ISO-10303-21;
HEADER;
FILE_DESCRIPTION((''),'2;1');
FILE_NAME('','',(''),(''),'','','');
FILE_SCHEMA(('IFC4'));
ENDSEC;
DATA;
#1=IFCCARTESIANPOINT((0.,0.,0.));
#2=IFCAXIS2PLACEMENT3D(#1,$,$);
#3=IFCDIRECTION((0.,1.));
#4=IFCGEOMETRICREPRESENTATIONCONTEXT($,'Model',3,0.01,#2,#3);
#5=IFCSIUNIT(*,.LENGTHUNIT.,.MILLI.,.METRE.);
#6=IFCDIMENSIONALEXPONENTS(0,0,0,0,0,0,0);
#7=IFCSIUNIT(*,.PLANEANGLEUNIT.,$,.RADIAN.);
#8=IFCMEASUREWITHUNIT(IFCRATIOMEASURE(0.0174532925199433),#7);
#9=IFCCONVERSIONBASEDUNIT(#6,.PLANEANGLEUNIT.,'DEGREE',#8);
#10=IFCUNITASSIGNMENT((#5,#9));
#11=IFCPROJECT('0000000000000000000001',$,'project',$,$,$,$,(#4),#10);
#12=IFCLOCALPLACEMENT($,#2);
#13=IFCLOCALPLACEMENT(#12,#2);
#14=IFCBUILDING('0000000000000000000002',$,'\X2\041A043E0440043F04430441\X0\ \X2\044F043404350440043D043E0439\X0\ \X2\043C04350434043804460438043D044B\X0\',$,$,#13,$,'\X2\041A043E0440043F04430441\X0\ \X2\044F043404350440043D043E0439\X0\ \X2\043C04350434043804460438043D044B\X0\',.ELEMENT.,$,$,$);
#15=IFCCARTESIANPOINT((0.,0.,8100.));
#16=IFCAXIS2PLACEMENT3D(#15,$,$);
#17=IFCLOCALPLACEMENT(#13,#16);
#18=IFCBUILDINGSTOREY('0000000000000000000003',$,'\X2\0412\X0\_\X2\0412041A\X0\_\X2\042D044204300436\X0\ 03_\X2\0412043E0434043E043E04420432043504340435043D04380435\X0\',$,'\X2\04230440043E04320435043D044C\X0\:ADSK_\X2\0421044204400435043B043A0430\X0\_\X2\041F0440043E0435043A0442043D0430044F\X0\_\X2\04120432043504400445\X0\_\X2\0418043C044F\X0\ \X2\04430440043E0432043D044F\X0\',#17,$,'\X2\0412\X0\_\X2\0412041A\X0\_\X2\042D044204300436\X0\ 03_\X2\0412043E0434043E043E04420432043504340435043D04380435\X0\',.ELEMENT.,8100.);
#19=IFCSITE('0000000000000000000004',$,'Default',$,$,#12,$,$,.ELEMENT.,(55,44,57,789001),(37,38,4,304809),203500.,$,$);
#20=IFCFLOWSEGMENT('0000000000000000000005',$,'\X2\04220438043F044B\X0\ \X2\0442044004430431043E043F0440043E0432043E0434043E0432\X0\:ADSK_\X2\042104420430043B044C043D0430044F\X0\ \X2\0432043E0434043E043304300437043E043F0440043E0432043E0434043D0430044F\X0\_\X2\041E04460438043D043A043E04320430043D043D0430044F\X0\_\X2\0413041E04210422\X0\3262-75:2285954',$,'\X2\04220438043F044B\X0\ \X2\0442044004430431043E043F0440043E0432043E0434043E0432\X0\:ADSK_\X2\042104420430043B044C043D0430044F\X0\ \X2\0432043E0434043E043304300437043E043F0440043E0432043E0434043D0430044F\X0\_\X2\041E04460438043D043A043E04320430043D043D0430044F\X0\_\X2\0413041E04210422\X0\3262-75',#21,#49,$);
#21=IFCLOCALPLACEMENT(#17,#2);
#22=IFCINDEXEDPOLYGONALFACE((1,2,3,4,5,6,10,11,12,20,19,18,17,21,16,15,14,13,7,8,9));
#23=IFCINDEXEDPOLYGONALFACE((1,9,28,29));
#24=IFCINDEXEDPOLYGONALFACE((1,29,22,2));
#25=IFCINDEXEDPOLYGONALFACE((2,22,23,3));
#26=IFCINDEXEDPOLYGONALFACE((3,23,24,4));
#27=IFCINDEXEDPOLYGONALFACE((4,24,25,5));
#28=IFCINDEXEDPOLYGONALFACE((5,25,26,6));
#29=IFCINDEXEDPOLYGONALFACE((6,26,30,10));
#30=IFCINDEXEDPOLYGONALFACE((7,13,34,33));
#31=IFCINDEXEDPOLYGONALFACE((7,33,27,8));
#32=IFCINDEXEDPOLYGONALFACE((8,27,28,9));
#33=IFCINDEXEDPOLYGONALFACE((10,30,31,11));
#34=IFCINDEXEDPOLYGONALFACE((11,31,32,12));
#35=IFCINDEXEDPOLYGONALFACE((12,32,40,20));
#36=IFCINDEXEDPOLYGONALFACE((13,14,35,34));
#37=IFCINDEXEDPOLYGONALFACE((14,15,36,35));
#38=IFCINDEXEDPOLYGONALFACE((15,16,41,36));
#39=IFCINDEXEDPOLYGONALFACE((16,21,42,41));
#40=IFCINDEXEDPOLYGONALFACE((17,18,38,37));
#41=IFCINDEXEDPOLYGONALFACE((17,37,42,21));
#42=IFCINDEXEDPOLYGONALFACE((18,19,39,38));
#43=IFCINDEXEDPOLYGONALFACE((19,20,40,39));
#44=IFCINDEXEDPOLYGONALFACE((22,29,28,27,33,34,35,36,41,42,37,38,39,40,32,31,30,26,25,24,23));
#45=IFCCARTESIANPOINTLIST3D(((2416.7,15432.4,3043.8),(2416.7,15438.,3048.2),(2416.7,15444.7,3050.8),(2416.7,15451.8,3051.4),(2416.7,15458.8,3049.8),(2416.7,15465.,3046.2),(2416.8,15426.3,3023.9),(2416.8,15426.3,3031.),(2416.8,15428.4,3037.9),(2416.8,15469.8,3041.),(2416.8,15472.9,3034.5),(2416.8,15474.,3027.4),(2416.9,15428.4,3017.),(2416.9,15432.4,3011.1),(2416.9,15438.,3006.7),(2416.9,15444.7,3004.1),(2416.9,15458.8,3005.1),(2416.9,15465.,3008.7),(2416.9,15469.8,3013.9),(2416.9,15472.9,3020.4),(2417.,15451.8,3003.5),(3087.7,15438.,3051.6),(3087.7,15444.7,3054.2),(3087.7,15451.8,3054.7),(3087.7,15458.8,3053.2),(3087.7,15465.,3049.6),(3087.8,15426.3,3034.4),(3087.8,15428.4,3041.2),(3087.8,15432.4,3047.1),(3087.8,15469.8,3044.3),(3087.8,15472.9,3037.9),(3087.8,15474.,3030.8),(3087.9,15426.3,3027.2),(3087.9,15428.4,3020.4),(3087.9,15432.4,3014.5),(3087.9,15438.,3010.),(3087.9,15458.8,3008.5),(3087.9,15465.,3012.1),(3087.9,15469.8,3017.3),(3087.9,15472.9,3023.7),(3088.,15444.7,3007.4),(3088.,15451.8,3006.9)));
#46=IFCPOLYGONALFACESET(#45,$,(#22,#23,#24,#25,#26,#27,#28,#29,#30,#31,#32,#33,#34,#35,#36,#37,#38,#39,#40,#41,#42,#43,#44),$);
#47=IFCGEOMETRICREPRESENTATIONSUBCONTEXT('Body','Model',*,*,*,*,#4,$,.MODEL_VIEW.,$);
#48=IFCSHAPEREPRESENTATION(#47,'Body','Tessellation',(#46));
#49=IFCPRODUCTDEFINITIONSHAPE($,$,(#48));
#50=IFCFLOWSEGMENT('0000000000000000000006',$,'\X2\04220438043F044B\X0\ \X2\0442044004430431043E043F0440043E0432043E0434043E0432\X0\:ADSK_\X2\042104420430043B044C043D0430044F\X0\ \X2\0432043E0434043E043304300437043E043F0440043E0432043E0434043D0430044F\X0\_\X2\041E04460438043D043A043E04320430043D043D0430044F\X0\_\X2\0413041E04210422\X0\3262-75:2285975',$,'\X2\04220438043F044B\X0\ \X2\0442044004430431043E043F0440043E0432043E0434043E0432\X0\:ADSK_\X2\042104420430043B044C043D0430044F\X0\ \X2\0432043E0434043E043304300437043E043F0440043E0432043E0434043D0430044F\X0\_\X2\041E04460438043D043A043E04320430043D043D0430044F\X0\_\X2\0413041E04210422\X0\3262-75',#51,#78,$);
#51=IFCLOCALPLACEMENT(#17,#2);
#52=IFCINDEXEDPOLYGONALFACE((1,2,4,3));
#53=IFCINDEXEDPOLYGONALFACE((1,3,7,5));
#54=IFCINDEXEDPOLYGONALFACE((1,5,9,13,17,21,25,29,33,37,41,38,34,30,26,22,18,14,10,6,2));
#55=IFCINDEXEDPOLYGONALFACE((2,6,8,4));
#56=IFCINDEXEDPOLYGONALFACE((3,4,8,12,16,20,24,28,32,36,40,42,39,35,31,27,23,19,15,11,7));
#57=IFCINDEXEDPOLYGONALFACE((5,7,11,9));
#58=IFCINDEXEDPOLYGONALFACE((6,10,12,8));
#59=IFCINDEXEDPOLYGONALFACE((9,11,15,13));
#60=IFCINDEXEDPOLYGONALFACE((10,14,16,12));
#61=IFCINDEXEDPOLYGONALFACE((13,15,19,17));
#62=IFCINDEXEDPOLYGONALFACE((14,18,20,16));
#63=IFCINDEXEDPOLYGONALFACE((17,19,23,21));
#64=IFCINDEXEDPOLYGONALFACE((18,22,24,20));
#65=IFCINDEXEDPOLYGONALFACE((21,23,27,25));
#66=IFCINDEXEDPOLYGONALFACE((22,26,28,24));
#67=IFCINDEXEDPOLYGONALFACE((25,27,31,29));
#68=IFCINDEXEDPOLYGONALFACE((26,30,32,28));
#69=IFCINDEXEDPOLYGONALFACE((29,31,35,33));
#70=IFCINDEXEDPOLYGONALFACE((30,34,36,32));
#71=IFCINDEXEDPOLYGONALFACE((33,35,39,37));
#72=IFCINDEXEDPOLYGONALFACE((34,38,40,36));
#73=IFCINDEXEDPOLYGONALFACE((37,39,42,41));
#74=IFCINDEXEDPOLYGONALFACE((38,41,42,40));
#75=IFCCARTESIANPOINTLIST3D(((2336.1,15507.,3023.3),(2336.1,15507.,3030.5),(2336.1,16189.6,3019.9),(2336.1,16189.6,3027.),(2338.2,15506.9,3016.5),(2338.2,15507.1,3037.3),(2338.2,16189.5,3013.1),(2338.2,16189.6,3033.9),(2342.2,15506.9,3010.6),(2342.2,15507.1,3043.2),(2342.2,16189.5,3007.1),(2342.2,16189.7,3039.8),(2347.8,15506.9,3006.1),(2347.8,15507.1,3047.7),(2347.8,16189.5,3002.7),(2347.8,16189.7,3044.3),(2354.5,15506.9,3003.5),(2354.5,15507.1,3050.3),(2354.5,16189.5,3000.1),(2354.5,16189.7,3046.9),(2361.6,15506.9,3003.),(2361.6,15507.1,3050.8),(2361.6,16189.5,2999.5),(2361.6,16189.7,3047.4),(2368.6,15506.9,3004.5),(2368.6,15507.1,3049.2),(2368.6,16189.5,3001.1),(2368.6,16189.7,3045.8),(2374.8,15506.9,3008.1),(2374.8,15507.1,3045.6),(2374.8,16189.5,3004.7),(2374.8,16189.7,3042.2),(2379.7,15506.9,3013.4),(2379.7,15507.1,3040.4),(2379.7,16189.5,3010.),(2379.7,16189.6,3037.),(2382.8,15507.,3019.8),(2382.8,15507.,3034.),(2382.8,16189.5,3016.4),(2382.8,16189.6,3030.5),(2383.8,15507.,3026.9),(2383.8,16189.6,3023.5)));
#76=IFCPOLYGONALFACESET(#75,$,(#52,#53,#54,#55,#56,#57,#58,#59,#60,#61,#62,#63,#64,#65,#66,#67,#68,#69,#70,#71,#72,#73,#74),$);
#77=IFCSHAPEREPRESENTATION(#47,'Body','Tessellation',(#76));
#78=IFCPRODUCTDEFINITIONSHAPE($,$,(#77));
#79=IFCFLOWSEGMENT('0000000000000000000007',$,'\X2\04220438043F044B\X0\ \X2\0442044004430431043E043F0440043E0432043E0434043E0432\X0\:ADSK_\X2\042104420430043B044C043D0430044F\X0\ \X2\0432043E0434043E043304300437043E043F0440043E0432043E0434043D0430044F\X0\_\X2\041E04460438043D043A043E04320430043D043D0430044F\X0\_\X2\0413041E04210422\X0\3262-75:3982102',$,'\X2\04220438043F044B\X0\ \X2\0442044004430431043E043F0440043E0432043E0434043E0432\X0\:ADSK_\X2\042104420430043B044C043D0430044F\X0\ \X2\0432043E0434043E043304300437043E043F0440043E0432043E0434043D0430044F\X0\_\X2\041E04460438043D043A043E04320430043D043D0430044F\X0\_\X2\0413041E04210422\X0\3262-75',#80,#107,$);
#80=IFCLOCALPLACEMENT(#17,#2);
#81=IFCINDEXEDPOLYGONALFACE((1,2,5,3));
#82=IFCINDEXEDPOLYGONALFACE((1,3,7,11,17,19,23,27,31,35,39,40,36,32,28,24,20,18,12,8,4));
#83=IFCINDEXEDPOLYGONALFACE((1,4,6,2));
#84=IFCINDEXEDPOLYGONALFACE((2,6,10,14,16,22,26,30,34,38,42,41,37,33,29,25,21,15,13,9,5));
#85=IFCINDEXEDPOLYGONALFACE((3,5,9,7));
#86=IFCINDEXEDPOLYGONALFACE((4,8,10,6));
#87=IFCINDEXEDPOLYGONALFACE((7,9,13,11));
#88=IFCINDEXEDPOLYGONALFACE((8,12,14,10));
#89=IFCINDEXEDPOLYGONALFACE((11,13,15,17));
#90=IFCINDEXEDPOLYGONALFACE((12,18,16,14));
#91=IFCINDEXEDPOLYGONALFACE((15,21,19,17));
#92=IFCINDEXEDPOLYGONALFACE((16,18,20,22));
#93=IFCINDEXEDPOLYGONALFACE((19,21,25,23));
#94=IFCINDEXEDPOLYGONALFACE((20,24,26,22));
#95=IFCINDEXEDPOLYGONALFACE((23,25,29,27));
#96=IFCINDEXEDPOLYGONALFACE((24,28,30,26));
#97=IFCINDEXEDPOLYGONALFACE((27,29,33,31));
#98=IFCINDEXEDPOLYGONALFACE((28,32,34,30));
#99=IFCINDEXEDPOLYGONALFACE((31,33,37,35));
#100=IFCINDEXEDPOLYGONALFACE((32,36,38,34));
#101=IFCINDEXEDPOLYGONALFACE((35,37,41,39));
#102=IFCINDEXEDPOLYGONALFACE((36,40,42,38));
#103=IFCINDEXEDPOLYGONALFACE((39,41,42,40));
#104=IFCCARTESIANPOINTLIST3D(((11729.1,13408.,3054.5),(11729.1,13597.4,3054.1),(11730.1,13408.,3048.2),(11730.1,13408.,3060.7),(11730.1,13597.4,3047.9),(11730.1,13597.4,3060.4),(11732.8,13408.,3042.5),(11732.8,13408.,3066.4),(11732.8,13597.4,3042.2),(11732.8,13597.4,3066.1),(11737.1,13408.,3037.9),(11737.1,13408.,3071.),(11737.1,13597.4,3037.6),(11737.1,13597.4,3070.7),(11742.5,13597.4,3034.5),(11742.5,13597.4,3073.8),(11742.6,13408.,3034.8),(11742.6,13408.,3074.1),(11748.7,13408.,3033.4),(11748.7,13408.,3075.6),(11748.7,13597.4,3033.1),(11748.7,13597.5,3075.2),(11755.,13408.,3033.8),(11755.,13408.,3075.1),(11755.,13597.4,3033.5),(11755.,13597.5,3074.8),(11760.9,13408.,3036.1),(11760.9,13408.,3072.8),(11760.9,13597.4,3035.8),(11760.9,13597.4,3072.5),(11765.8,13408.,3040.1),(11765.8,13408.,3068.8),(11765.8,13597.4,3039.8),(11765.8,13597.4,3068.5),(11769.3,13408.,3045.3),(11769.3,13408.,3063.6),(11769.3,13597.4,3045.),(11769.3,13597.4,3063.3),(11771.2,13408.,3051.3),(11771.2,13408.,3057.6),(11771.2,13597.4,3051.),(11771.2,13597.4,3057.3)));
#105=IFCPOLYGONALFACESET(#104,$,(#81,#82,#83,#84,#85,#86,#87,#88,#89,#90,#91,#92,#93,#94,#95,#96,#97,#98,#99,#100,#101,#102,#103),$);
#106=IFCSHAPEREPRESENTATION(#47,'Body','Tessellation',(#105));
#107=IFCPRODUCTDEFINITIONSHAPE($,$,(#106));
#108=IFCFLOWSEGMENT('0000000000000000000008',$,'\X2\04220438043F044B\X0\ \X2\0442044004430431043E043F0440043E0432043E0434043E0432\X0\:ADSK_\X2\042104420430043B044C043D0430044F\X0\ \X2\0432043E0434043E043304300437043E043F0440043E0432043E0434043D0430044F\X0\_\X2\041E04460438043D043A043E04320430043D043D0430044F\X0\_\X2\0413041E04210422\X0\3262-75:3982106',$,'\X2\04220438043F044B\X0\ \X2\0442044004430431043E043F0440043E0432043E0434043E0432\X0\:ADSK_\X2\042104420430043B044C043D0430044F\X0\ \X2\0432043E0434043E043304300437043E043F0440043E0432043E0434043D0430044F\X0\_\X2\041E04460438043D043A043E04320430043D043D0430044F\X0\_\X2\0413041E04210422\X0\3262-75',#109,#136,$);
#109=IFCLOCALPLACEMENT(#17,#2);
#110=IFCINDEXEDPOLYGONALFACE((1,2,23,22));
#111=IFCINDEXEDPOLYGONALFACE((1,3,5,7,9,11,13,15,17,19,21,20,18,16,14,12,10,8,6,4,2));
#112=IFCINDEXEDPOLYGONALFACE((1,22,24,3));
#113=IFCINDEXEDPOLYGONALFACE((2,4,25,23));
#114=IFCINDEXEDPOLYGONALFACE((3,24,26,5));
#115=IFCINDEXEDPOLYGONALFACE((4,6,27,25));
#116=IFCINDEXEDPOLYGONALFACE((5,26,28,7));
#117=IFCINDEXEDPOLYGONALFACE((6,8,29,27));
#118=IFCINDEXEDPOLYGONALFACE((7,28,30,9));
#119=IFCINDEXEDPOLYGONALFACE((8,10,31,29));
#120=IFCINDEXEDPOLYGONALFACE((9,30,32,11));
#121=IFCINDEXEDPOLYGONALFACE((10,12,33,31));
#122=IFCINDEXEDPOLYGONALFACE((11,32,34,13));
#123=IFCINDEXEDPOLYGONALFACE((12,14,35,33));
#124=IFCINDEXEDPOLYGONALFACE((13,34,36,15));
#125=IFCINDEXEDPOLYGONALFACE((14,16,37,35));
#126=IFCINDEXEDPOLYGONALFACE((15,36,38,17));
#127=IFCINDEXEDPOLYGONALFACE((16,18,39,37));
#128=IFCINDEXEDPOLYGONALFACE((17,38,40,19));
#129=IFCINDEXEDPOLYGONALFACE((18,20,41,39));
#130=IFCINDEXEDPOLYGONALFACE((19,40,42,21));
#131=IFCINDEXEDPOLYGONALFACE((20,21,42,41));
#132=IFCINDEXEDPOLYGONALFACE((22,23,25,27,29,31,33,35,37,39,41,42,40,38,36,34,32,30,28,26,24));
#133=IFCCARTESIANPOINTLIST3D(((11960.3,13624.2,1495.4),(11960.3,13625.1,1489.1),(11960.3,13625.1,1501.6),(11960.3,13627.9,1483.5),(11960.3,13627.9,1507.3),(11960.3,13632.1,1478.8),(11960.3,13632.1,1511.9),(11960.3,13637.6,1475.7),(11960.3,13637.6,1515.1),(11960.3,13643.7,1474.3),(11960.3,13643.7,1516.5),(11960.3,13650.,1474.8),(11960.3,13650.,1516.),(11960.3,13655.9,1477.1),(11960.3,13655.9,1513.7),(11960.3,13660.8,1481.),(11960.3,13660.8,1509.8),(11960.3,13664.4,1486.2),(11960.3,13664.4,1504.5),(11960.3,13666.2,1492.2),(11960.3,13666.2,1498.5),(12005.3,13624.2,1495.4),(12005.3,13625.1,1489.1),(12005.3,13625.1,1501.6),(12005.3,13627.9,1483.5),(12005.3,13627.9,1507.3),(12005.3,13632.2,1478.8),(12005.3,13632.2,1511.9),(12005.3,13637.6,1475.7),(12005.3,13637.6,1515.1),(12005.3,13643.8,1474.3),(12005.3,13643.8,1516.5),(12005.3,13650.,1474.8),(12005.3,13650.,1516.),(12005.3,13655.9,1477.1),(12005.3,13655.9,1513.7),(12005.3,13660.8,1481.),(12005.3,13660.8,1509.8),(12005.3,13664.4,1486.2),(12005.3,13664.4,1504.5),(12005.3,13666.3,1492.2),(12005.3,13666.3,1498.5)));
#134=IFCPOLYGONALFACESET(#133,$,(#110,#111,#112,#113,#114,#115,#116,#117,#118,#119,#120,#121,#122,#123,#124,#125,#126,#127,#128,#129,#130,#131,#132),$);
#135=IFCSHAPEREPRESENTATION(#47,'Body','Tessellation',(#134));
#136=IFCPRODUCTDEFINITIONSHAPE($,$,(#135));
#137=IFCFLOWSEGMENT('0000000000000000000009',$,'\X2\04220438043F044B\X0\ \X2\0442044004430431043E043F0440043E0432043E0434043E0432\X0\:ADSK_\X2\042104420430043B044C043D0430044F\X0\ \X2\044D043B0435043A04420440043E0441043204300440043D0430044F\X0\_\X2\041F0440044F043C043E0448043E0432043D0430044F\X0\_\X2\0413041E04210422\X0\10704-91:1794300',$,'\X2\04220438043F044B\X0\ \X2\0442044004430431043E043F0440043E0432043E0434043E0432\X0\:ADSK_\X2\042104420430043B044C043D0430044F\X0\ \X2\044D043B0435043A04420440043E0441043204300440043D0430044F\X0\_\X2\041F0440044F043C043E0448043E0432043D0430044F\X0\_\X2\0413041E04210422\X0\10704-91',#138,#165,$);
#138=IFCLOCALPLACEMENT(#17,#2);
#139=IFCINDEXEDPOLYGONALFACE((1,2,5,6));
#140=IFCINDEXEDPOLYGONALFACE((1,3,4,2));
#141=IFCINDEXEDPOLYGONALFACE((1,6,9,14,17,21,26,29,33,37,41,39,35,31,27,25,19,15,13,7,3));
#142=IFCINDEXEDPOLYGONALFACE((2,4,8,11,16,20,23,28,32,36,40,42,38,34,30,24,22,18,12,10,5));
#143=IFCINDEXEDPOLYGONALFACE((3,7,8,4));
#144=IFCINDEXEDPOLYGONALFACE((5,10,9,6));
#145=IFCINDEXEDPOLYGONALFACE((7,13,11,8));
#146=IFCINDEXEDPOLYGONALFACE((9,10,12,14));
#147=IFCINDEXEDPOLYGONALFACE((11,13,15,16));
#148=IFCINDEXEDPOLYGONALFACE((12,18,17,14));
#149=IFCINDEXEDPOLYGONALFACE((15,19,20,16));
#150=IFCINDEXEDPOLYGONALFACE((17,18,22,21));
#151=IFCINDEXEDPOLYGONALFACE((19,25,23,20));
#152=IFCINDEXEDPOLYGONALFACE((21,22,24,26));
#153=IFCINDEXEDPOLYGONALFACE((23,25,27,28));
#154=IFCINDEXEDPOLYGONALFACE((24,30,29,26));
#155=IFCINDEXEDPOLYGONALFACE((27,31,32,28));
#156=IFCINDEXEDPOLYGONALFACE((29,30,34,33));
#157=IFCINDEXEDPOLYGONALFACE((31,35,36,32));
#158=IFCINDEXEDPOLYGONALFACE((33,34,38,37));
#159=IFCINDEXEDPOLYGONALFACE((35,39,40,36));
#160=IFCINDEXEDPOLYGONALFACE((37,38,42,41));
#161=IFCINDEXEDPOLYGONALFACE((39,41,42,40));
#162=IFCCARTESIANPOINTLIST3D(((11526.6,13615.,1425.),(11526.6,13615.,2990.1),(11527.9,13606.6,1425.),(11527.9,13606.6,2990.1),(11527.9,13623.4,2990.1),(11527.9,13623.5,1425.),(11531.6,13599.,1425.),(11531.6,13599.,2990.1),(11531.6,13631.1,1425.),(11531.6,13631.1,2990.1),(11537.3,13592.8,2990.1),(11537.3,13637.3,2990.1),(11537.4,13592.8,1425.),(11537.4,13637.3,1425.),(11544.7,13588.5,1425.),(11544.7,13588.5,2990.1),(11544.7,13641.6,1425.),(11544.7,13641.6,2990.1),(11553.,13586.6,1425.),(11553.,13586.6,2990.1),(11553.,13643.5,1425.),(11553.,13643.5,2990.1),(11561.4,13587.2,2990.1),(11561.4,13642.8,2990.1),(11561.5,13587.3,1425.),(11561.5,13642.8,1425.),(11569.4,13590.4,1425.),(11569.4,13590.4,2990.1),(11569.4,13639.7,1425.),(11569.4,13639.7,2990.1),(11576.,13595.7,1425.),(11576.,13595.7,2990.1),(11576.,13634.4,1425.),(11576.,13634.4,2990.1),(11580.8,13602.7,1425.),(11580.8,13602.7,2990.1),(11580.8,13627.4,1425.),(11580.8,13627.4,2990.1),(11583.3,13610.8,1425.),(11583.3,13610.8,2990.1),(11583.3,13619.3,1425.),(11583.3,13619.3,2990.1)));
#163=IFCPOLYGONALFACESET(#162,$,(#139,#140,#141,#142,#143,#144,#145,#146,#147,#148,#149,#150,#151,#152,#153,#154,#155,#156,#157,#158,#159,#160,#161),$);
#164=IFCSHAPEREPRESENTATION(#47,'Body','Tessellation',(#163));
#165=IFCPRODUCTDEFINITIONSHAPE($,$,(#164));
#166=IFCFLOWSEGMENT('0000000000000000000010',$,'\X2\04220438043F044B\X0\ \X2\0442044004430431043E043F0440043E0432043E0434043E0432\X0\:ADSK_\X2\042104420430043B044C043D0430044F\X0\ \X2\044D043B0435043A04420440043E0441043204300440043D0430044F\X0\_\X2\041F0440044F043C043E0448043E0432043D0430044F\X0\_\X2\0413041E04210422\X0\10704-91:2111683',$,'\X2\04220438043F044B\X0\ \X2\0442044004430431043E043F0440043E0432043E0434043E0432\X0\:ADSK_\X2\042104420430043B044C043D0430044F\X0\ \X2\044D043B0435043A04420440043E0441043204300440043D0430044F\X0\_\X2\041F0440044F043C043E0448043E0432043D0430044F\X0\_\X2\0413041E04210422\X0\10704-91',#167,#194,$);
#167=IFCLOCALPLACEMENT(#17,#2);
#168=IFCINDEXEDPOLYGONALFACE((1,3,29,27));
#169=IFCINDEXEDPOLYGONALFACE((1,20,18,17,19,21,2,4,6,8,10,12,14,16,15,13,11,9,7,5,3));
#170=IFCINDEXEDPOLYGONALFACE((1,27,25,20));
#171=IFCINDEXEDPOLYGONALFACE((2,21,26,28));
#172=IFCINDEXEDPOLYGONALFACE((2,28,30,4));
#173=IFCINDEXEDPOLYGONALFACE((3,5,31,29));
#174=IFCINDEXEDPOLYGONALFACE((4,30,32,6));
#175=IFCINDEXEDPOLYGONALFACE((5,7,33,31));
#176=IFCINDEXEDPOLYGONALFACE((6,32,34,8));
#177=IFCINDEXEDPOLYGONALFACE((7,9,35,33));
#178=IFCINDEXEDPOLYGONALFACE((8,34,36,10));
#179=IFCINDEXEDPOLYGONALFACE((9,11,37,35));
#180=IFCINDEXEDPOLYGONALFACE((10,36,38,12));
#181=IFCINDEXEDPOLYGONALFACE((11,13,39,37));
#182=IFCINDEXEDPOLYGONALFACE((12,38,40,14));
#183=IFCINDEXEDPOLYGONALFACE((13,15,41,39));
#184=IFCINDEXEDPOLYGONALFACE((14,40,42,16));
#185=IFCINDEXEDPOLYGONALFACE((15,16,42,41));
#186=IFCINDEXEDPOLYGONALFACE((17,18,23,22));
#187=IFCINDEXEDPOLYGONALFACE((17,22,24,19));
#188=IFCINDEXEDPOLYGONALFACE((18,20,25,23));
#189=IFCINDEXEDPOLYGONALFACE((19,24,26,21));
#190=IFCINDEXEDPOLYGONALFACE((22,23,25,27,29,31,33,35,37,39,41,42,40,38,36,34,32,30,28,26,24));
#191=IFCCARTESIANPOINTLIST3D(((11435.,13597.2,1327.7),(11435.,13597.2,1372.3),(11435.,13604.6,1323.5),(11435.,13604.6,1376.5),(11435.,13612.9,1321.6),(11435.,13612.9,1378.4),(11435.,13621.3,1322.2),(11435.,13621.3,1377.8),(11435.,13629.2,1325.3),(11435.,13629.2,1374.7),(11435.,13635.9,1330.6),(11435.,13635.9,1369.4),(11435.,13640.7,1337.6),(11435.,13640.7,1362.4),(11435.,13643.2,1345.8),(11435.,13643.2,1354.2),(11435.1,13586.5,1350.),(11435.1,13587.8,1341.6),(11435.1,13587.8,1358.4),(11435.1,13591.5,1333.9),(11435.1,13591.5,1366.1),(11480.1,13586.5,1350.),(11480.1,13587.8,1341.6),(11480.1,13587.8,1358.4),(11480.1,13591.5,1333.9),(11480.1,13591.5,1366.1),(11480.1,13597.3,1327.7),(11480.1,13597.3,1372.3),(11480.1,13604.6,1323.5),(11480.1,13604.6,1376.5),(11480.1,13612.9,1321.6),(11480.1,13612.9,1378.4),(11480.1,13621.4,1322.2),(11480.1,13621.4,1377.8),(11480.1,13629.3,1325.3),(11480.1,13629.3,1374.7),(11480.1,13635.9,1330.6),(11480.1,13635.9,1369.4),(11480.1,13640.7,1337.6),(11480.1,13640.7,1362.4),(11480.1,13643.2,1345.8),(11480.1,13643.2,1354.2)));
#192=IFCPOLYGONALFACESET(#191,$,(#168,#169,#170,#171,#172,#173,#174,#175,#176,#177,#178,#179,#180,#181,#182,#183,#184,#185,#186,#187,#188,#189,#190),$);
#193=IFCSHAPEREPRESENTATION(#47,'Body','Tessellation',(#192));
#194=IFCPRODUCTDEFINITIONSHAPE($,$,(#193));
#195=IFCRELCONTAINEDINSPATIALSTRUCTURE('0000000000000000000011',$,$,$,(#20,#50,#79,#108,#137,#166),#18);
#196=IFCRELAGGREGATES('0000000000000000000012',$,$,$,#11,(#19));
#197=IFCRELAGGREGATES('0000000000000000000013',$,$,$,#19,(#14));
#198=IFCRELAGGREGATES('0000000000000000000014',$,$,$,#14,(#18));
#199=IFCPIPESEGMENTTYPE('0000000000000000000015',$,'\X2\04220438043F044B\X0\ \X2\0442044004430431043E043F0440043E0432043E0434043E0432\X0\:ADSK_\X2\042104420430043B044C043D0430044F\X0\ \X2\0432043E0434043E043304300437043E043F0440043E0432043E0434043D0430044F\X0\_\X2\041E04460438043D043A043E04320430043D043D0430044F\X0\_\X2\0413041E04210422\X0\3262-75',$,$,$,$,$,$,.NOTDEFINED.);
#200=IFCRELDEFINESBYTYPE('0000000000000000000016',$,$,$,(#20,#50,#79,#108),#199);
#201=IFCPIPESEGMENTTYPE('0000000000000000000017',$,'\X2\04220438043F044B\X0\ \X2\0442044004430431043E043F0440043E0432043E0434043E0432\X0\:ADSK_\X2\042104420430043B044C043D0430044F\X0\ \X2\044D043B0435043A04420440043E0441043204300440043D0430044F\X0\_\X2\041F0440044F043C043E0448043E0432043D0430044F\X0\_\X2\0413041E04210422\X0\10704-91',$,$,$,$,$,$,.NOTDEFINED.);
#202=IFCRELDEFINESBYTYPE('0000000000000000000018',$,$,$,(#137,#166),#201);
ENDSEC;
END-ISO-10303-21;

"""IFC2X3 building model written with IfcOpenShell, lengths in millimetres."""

from ifc_helpers import new_model, entity, si_unit, converted_unit, direction, frame, origin, origin_2d_with_axis, place, context, subcontext, project, spatial, circle, extrude, type_object, element, save


model = new_model("IFC2X3")

# Units and contexts
model_context = context("Model", 3, precision=0.01, world=origin(), true_north=direction((0.0, 1.0)))
body_context = subcontext(model_context, "Body", "Model", "MODEL_VIEW")
ifc_project = project(units=[si_unit("LENGTHUNIT", "METRE", prefix="MILLI"), converted_unit("PLANEANGLEUNIT", "DEGREE", entity("IfcRatioMeasure", 0.0174532925199433), si_unit("PLANEANGLEUNIT", "RADIAN"), dimensions=[0, 0, 0, 0, 0, 0, 0])], contexts=[model_context])

# Site, building, storey
site_placement = place(None, origin())
site = spatial("IfcSite", under=ifc_project, at=site_placement, Name="Default", CompositionType="ELEMENT", RefLatitude=(55, 44, 57, 789001), RefLongitude=(37, 38, 4, 304809), RefElevation=203500.0)
building_placement = place(site_placement, origin())
building = spatial("IfcBuilding", under=site, at=building_placement, Name="Корпус ядерной медицины", LongName="Корпус ядерной медицины", CompositionType="ELEMENT")
storey_placement = place(building_placement, frame((0.0, 0.0, 8100.0)))
storey = spatial("IfcBuildingStorey", under=building, at=storey_placement, Name="В_ВК_Этаж 03_Водоотведение", ObjectType="Уровень:ADSK_Стрелка_Проектная_Вверх_Имя уровня", LongName="В_ВК_Этаж 03_Водоотведение", CompositionType="ELEMENT", Elevation=8100.0)

# Flow segments
pipe_segment_type_1 = type_object("IfcPipeSegmentType", Name="Типы трубопроводов:ADSK_Стальная водогазопроводная_Оцинкованная_ГОСТ3262-75", PredefinedType="NOTDEFINED")
flow_segment_1_placement = place(storey_placement, frame((2416.7, 15424.4, 3001.9)))
element("IfcFlowSegment", 1, at=flow_segment_1_placement, inside=storey, type_object=pipe_segment_type_1, Name="Типы трубопроводов:ADSK_Стальная водогазопроводная_Оцинкованная_ГОСТ3262-75:2285954", ObjectType="Типы трубопроводов:ADSK_Стальная водогазопроводная_Оцинкованная_ГОСТ3262-75", context=body_context, shape_type="SweptSolid", body=[
    extrude(circle(Radius=24.0, at=origin_2d_with_axis()), frame((0.1, 25.6, 25.6), z_axis=(0.999987, 0.000001, 0.005017), x_axis=(-0.000001, 1.0, 0.0)), (0.0, 0.0, 1.0), 671.0),
])
flow_segment_2_placement = place(storey_placement, frame((2334.2, 15506.9, 2997.9)))
element("IfcFlowSegment", 2, at=flow_segment_2_placement, inside=storey, type_object=pipe_segment_type_1, Name="Типы трубопроводов:ADSK_Стальная водогазопроводная_Оцинкованная_ГОСТ3262-75:2285975", ObjectType="Типы трубопроводов:ADSK_Стальная водогазопроводная_Оцинкованная_ГОСТ3262-75", context=body_context, shape_type="SweptSolid", body=[
    extrude(circle(Radius=24.0, at=origin_2d_with_axis()), frame((25.6, 682.7, 25.6), z_axis=(0.0, -0.999988, 0.005), x_axis=(1.0, 0.0, 0.0)), (0.0, 0.0, 1.0), 682.6),
])
flow_segment_3_placement = place(storey_placement, frame((11727.5, 13408.0, 3031.4)))
element("IfcFlowSegment", 3, at=flow_segment_3_placement, inside=storey, type_object=pipe_segment_type_1, Name="Типы трубопроводов:ADSK_Стальная водогазопроводная_Оцинкованная_ГОСТ3262-75:3982102", ObjectType="Типы трубопроводов:ADSK_Стальная водогазопроводная_Оцинкованная_ГОСТ3262-75", context=body_context, shape_type="SweptSolid", body=[
    extrude(circle(Radius=21.1, at=origin_2d_with_axis()), frame((22.8, 0.0, 23.1), z_axis=(-0.000018, 0.999999, -0.001684), x_axis=(-1.0, -0.000018, 0.0)), (0.0, 0.0, 1.0), 189.4),
])
flow_segment_4_placement = place(storey_placement, frame((11960.3, 13622.6, 1472.6)))
element("IfcFlowSegment", 4, at=flow_segment_4_placement, inside=storey, type_object=pipe_segment_type_1, Name="Типы трубопроводов:ADSK_Стальная водогазопроводная_Оцинкованная_ГОСТ3262-75:3982106", ObjectType="Типы трубопроводов:ADSK_Стальная водогазопроводная_Оцинкованная_ГОСТ3262-75", context=body_context, shape_type="SweptSolid", body=[
    extrude(circle(Radius=21.1, at=origin_2d_with_axis()), frame((0.0, 22.8, 22.8), z_axis=(1.0, 0.000227, 0.0), x_axis=(0.000227, -1.0, 0.0)), (0.0, 0.0, 1.0), 45.0),
])
pipe_segment_type_2 = type_object("IfcPipeSegmentType", Name="Типы трубопроводов:ADSK_Стальная электросварная_Прямошовная_ГОСТ10704-91", PredefinedType="NOTDEFINED")
flow_segment_5_placement = place(storey_placement, frame((11525.0, 13584.9, 1425.0)))
element("IfcFlowSegment", 5, at=flow_segment_5_placement, inside=storey, type_object=pipe_segment_type_2, Name="Типы трубопроводов:ADSK_Стальная электросварная_Прямошовная_ГОСТ10704-91:1794300", ObjectType="Типы трубопроводов:ADSK_Стальная электросварная_Прямошовная_ГОСТ10704-91", context=body_context, shape_type="SweptSolid", body=[
    extrude(circle(Radius=28.5, at=origin_2d_with_axis()), frame((30.1, 30.1, 0.0), z_axis=(-0.000009, -0.000009, 1.0), x_axis=(-1.0, 0.0, -0.000009)), (0.0, 0.0, 1.0), 1565.1),
])
flow_segment_6_placement = place(storey_placement, frame((11435.0, 13584.9, 1319.9)))
element("IfcFlowSegment", 6, at=flow_segment_6_placement, inside=storey, type_object=pipe_segment_type_2, Name="Типы трубопроводов:ADSK_Стальная электросварная_Прямошовная_ГОСТ10704-91:2111683", ObjectType="Типы трубопроводов:ADSK_Стальная электросварная_Прямошовная_ГОСТ10704-91", context=body_context, shape_type="SweptSolid", body=[
    extrude(circle(Radius=28.5, at=origin_2d_with_axis()), frame((0.0, 30.1, 30.1), z_axis=(1.0, 0.000557, 0.0), x_axis=(0.000557, -1.0, 0.0)), (0.0, 0.0, 1.0), 45.1),
])

save(model, "model.ifc")
